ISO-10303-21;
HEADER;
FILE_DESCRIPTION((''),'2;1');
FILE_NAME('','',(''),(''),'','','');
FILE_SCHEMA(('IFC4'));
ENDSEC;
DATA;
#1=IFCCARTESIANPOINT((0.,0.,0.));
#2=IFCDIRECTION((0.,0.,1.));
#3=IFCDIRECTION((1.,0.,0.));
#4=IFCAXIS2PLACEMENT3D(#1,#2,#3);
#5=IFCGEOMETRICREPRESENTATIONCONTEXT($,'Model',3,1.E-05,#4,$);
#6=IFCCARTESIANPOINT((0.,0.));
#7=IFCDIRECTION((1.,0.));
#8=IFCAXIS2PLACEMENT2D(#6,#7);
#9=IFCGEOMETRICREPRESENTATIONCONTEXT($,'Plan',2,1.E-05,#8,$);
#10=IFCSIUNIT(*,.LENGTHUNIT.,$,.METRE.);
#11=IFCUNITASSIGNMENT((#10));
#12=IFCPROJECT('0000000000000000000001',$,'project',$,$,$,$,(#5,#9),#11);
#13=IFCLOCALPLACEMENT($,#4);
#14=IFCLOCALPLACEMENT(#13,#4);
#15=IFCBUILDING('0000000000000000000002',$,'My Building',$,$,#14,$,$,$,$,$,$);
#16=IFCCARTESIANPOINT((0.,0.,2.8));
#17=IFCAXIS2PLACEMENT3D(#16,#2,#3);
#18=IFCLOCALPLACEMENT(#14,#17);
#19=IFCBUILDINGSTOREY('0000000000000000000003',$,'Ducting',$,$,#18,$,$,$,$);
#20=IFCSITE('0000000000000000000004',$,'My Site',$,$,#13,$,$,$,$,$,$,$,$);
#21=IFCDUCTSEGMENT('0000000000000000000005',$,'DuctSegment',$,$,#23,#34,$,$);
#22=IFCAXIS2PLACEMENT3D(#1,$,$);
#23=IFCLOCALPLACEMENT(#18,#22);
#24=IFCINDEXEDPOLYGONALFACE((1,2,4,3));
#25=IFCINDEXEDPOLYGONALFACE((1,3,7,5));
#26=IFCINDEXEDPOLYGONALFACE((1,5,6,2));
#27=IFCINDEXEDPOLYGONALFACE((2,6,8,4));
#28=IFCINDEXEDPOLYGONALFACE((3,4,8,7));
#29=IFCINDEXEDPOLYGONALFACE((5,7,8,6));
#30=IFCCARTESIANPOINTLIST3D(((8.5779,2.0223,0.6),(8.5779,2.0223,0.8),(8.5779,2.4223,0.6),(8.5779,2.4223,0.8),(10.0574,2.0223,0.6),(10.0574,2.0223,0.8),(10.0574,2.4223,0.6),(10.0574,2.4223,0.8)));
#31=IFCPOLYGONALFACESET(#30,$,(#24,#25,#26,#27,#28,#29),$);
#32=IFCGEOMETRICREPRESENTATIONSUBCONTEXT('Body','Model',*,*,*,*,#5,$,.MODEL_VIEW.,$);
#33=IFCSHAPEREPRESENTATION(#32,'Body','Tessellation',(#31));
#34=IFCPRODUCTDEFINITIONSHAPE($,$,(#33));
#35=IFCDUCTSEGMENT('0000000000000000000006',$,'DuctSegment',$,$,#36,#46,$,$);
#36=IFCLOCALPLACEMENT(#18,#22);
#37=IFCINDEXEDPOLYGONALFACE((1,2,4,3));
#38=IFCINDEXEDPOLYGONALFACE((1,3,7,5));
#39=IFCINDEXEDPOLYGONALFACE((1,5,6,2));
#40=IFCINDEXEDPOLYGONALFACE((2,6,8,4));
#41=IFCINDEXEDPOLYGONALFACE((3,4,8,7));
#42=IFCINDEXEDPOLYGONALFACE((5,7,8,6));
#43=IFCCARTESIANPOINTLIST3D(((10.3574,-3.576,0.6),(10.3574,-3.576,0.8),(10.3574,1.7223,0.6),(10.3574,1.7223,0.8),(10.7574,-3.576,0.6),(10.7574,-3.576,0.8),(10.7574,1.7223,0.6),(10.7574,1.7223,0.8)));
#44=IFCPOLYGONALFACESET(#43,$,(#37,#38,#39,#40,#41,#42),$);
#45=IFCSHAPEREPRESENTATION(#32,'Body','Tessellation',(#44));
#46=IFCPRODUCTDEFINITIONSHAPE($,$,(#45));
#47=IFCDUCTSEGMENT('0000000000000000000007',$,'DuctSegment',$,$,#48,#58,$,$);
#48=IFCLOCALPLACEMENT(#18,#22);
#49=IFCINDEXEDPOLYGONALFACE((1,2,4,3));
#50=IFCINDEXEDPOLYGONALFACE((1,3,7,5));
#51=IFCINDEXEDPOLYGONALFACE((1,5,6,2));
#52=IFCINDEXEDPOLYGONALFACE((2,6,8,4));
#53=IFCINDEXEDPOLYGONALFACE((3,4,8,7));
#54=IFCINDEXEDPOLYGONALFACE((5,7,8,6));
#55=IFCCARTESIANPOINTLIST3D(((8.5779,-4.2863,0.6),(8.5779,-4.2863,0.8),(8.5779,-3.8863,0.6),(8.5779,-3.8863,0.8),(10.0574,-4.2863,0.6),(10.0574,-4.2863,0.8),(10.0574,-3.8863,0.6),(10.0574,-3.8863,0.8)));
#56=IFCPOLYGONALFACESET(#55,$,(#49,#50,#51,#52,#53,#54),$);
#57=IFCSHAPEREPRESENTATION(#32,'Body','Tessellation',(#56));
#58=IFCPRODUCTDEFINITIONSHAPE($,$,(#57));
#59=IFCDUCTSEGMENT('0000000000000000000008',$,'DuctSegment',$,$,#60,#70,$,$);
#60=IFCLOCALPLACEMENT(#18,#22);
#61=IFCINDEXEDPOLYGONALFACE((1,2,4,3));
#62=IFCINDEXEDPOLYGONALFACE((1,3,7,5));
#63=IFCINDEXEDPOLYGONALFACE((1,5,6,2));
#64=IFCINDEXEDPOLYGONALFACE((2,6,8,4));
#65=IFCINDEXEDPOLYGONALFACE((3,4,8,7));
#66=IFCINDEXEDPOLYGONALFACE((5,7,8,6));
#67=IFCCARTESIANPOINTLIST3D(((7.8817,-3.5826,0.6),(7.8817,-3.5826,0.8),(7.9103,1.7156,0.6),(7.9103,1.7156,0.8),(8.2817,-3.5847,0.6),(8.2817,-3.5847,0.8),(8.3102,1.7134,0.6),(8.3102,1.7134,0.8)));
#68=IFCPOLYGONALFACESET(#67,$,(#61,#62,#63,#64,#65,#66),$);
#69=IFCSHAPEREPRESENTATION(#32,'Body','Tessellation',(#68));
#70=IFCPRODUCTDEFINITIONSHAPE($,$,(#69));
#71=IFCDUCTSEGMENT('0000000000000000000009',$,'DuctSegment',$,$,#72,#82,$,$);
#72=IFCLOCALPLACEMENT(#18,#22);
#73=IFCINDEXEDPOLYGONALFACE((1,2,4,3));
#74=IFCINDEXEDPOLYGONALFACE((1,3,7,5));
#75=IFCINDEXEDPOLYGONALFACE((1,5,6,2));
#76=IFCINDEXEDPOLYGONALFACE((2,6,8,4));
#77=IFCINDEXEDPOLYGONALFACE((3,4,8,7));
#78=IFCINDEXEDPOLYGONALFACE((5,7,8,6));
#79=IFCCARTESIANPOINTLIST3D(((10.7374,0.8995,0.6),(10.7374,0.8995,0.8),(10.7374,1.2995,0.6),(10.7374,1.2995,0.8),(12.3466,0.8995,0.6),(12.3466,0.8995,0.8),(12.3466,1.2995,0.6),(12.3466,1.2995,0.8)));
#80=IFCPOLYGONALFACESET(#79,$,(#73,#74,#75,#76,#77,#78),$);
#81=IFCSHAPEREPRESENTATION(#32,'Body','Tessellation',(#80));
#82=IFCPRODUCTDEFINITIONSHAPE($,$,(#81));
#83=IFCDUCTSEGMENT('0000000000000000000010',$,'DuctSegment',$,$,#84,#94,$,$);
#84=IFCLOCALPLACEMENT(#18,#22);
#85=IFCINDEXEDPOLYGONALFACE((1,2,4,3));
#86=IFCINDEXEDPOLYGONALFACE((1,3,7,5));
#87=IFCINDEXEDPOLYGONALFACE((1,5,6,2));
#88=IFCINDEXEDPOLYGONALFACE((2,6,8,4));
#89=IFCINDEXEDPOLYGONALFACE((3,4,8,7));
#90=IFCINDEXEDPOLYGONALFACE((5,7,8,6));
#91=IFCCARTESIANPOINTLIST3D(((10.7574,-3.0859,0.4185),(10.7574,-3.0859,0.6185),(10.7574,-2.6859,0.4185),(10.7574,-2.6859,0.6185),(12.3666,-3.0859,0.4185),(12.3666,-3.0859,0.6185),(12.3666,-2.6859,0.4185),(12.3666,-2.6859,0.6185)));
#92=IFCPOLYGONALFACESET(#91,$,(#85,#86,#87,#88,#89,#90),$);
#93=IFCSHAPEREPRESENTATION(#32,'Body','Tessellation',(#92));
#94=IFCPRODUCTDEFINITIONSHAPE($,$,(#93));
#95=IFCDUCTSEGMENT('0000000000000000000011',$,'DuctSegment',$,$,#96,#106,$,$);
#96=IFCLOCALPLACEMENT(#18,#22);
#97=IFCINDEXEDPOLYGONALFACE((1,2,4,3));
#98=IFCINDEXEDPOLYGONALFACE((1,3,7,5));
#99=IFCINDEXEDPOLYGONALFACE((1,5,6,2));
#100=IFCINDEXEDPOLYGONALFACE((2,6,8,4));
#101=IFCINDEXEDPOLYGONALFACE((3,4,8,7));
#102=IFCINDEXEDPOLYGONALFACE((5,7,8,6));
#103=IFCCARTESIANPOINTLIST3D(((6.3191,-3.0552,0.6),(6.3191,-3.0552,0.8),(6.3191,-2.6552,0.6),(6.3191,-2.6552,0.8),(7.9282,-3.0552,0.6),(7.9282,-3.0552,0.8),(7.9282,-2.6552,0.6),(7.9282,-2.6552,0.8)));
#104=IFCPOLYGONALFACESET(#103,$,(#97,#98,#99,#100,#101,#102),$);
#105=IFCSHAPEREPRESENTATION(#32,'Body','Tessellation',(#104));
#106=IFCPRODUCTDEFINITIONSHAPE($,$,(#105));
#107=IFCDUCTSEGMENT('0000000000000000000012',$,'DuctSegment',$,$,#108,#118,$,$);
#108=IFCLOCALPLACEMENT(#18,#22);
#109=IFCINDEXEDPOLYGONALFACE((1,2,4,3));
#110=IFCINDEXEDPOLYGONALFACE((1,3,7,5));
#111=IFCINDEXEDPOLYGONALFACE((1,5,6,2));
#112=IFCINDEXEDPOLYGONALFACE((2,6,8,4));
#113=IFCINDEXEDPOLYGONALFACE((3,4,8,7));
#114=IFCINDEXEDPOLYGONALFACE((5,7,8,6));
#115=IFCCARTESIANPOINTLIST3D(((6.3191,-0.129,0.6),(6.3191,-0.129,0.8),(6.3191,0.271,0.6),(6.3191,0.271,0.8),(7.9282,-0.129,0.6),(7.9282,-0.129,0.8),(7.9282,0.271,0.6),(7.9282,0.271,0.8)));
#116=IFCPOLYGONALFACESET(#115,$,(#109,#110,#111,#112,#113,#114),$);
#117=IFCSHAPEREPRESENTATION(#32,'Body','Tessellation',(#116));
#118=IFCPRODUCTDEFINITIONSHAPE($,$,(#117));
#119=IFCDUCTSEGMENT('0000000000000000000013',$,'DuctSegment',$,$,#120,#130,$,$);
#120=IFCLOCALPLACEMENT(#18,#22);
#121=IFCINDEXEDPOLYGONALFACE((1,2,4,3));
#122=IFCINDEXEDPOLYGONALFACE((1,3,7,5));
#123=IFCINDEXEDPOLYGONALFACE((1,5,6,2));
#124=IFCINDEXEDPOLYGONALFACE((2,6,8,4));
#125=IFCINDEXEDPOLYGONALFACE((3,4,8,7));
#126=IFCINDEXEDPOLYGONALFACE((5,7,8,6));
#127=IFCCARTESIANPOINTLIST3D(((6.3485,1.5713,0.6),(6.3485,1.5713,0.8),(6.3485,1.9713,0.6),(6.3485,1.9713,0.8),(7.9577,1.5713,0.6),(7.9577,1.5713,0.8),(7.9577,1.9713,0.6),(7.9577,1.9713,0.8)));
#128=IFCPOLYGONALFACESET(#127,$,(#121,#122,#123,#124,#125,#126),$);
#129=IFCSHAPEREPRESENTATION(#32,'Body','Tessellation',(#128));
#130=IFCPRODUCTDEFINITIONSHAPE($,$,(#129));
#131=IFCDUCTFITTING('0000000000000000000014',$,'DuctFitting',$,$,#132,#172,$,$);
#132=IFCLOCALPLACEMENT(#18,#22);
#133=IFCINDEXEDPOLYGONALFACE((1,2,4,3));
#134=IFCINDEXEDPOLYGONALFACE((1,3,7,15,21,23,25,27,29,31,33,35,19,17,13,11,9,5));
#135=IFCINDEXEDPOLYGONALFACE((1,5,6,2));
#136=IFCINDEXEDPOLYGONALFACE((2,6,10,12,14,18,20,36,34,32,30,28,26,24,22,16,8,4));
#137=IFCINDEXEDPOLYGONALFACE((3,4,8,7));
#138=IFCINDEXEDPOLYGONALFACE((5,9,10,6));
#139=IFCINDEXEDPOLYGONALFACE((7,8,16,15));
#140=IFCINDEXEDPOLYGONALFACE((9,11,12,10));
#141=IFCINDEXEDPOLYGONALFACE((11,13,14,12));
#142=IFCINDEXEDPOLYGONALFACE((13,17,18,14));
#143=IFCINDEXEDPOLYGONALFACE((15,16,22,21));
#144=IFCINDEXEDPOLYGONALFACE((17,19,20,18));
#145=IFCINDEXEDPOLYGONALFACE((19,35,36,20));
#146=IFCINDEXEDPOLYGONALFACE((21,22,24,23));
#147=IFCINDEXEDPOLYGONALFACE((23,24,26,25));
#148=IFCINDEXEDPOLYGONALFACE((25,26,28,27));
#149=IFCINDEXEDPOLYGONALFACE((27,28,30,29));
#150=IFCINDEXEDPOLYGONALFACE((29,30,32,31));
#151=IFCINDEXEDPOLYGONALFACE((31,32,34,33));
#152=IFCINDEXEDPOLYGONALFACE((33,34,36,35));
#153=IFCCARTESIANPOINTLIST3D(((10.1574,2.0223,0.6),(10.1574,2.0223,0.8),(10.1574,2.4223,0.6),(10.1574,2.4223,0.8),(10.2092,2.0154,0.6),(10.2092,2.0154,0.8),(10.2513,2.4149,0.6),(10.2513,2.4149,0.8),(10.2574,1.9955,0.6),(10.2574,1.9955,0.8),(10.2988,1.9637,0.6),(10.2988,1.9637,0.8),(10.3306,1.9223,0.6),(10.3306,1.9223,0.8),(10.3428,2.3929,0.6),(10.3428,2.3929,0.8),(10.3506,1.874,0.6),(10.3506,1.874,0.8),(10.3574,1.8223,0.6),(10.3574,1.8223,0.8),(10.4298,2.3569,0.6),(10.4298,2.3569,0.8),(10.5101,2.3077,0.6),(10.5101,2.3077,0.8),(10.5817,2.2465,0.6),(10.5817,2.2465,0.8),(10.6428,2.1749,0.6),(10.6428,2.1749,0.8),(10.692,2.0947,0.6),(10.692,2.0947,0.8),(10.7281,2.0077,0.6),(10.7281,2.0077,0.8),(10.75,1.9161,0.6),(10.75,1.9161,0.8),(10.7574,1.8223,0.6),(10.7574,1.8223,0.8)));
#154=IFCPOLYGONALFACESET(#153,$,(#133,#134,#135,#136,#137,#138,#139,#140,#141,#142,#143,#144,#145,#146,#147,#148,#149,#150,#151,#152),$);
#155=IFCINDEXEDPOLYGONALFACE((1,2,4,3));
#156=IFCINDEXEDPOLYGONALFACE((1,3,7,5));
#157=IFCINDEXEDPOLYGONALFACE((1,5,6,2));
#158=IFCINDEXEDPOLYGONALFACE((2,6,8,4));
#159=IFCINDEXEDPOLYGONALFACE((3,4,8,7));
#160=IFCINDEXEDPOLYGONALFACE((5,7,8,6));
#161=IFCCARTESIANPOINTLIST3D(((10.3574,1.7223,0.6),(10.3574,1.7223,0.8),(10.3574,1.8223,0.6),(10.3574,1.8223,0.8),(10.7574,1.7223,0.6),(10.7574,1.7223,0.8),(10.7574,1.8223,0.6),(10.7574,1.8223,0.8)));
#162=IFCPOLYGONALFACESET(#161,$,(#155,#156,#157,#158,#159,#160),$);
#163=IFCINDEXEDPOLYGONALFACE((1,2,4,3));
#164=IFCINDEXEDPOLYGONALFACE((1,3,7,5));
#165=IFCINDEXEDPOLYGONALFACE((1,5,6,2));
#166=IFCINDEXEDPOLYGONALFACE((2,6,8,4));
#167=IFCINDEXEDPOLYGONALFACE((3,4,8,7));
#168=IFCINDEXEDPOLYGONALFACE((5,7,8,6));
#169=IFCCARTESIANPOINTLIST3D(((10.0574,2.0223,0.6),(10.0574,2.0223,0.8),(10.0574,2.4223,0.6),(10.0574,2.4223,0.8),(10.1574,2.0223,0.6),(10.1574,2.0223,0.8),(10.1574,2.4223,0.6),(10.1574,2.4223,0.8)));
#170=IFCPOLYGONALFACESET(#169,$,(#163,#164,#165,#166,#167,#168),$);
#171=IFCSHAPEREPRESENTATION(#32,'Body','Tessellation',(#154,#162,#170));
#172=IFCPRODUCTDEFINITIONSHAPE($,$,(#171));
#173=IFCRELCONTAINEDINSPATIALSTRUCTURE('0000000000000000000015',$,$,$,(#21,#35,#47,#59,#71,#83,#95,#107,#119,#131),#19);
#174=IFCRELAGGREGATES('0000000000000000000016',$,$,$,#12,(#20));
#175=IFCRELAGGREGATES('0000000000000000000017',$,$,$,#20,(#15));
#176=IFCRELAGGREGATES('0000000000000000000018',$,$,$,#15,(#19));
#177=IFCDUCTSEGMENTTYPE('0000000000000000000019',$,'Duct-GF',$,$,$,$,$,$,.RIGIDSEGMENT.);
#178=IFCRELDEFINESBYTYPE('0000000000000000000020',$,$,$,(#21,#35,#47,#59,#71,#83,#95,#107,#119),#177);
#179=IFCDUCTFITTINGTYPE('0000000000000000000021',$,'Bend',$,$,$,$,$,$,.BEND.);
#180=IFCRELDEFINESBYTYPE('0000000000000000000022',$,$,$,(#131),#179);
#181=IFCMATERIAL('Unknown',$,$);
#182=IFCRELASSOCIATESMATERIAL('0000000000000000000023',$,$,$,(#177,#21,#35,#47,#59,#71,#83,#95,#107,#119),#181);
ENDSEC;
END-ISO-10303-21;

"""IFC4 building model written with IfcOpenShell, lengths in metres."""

from ifc_helpers import new_model, si_unit, frame, origin_with_axes, origin_2d_with_axis, place, context, subcontext, project, spatial, line, arc, indexed_curve, rectangle, outline, extrude, source, transform, mapped, material, material_profile, profile_set, profile_usage, type_object, type_shapes, element, save


model = new_model("IFC4")

# Units and contexts
model_context = context("Model", 3, precision=1e-05, world=origin_with_axes())
plan_context = context("Plan", 2, precision=1e-05, world=origin_2d_with_axis())
body_context = subcontext(model_context, "Body", "Model", "MODEL_VIEW")
ifc_project = project(units=[si_unit("LENGTHUNIT", "METRE")], contexts=[model_context, plan_context])

# Site, building, storey
site_placement = place(None, origin_with_axes())
site = spatial("IfcSite", under=ifc_project, at=site_placement, Name="My Site")
building_placement = place(site_placement, origin_with_axes())
building = spatial("IfcBuilding", under=site, at=building_placement, Name="My Building")
storey_placement = place(building_placement, frame((0.0, 0.0, 2.8), z_axis=(0.0, 0.0, 1.0), x_axis=(1.0, 0.0, 0.0)))
storey = spatial("IfcBuildingStorey", under=building, at=storey_placement, Name="Ducting")

# Duct segments
ifc_material = material(Name="Unknown")
ifc_material_profile_1 = material_profile(ifc_material, rectangle(XDim=0.4, YDim=0.2))
ifc_profile_set_1 = profile_set([ifc_material_profile_1])
ifc_profile_usage_1 = profile_usage(ifc_profile_set_1, cardinal=5)
duct_segment_type = type_object("IfcDuctSegmentType", Name="Duct-GF", PredefinedType="RIGIDSEGMENT", material=ifc_profile_set_1)
duct_segment_1_placement = place(storey_placement, frame((8.5779, 2.2223, 0.7), z_axis=(1.0, -0.000001, 0.000001), x_axis=(0.000001, 1.0, 0.0)))
element("IfcDuctSegment", 1, at=duct_segment_1_placement, inside=storey, type_object=duct_segment_type, material=ifc_profile_usage_1, Name="DuctSegment", context=body_context, shape_type="SweptSolid", body=[
    extrude(rectangle(XDim=0.4, YDim=0.2), origin_with_axes(), (0.0, 0.0, 1.0), 1.4795),
])
ifc_profile_usage_2 = profile_usage(ifc_profile_set_1, cardinal=5)
duct_segment_2_placement = place(storey_placement, frame((10.5574, 1.7223, 0.7), z_axis=(0.0, -1.0, 0.0), x_axis=(-1.0, 0.0, 0.0)))
element("IfcDuctSegment", 2, at=duct_segment_2_placement, inside=storey, type_object=duct_segment_type, material=ifc_profile_usage_2, Name="DuctSegment", context=body_context, shape_type="SweptSolid", body=[
    extrude(rectangle(XDim=0.4, YDim=0.2), origin_with_axes(), (0.0, 0.0, 1.0), 5.2983),
])
ifc_profile_usage_3 = profile_usage(ifc_profile_set_1, cardinal=5)
duct_segment_3_placement = place(storey_placement, frame((8.5779, -4.0863, 0.7), z_axis=(1.0, -0.000001, 0.000001), x_axis=(0.000001, 1.0, 0.0)))
element("IfcDuctSegment", 3, at=duct_segment_3_placement, inside=storey, type_object=duct_segment_type, material=ifc_profile_usage_3, Name="DuctSegment", context=body_context, shape_type="SweptSolid", body=[
    extrude(rectangle(XDim=0.4, YDim=0.2), origin_with_axes(), (0.0, 0.0, 1.0), 1.4795),
])
ifc_profile_usage_4 = profile_usage(ifc_profile_set_1, cardinal=5)
duct_segment_4_placement = place(storey_placement, frame((8.0817, -3.5837, 0.7), z_axis=(0.005395, 0.999985, 0.0), x_axis=(0.999985, -0.005395, 0.0)))
element("IfcDuctSegment", 4, at=duct_segment_4_placement, inside=storey, type_object=duct_segment_type, material=ifc_profile_usage_4, Name="DuctSegment", context=body_context, shape_type="SweptSolid", body=[
    extrude(rectangle(XDim=0.4, YDim=0.2), origin_with_axes(), (0.0, 0.0, 1.0), 5.2983),
])
ifc_profile_usage_5 = profile_usage(ifc_profile_set_1, cardinal=5)
duct_segment_5_placement = place(storey_placement, frame((10.7374, 1.0995, 0.7), z_axis=(1.0, 0.0, 0.0), x_axis=(0.0, 1.0, 0.0)))
element("IfcDuctSegment", 5, at=duct_segment_5_placement, inside=storey, type_object=duct_segment_type, material=ifc_profile_usage_5, Name="DuctSegment", context=body_context, shape_type="SweptSolid", body=[
    extrude(rectangle(XDim=0.4, YDim=0.2), origin_with_axes(), (0.0, 0.0, 1.0), 1.6092),
])
ifc_profile_usage_6 = profile_usage(ifc_profile_set_1, cardinal=5)
duct_segment_6_placement = place(storey_placement, frame((10.7574, -2.8859, 0.5185), z_axis=(1.0, 0.0, 0.0), x_axis=(0.0, 1.0, 0.0)))
element("IfcDuctSegment", 6, at=duct_segment_6_placement, inside=storey, type_object=duct_segment_type, material=ifc_profile_usage_6, Name="DuctSegment", context=body_context, shape_type="SweptSolid", body=[
    extrude(rectangle(XDim=0.4, YDim=0.2), origin_with_axes(), (0.0, 0.0, 1.0), 1.6092),
])
ifc_profile_usage_7 = profile_usage(ifc_profile_set_1, cardinal=5)
duct_segment_7_placement = place(storey_placement, frame((6.3191, -2.8552, 0.7), z_axis=(1.0, 0.0, 0.0), x_axis=(0.0, 1.0, 0.0)))
element("IfcDuctSegment", 7, at=duct_segment_7_placement, inside=storey, type_object=duct_segment_type, material=ifc_profile_usage_7, Name="DuctSegment", context=body_context, shape_type="SweptSolid", body=[
    extrude(rectangle(XDim=0.4, YDim=0.2), origin_with_axes(), (0.0, 0.0, 1.0), 1.6092),
])
ifc_profile_usage_8 = profile_usage(ifc_profile_set_1, cardinal=5)
duct_segment_8_placement = place(storey_placement, frame((6.3191, 0.071, 0.7), z_axis=(1.0, 0.0, 0.0), x_axis=(0.0, 1.0, 0.0)))
element("IfcDuctSegment", 8, at=duct_segment_8_placement, inside=storey, type_object=duct_segment_type, material=ifc_profile_usage_8, Name="DuctSegment", context=body_context, shape_type="SweptSolid", body=[
    extrude(rectangle(XDim=0.4, YDim=0.2), origin_with_axes(), (0.0, 0.0, 1.0), 1.6092),
])
ifc_profile_usage_9 = profile_usage(ifc_profile_set_1, cardinal=5)
duct_segment_9_placement = place(storey_placement, frame((6.3485, 1.7713, 0.7), z_axis=(1.0, 0.0, 0.0), x_axis=(0.0, 1.0, 0.0)))
element("IfcDuctSegment", 9, at=duct_segment_9_placement, inside=storey, type_object=duct_segment_type, material=ifc_profile_usage_9, Name="DuctSegment", context=body_context, shape_type="SweptSolid", body=[
    extrude(rectangle(XDim=0.4, YDim=0.2), origin_with_axes(), (0.0, 0.0, 1.0), 1.6092),
])

# Duct fitting
duct_fitting_type = type_object("IfcDuctFittingType", Name="Bend", PredefinedType="BEND")
shared_shape_1 = source(origin_with_axes(), body_context, "Body", "SweptSolid", [
    extrude(outline(indexed_curve([(0.2, 0.0), (0.2586, -0.1414), (0.4, -0.2), (0.4, -0.6), (-0.0243, -0.4243), (-0.2, 0.0)], segments=[arc(1, 2, 3), line(3, 4), arc(4, 5, 6), line(6, 1)])), frame((0.0, -0.1, -0.1), z_axis=(0.0, -1.0, 0.0), x_axis=(1.0, 0.0, 0.0)), (0.0, 0.0, -1.0), 0.2),
    extrude(rectangle(XDim=0.4, YDim=0.2), origin_with_axes(), (0.0, 0.0, -1.0), 0.1),
    extrude(rectangle(XDim=0.4, YDim=0.2), frame((0.4, 0.0, -0.5), z_axis=(1.0, 0.0, -0.000001), x_axis=(0.000001, 0.0, 1.0)), (0.0, 0.0, 1.0), 0.1),
])
type_shapes(duct_fitting_type, [shared_shape_1])
for number, where, z_axis, x_axis, name in (
    (10, (10.5574, 1.7223, 0.7), (0.0, -1.0, 0.0), (-1.0, 0.0, 0.0), "DuctFitting"),
):
    element("IfcDuctFitting", number, at=place(storey_placement, frame(where, z_axis=z_axis, x_axis=x_axis)), inside=storey, type_object=duct_fitting_type, Name=name, context=body_context, shape_type="MappedRepresentation", body=[
        mapped(shared_shape_1, transform((0.0, 0.0, 0.0), x_axis=(1.0, 0.0, 0.0), y_axis=(0.0, 1.0, 0.0), z_axis=(0.0, 0.0, 1.0), scale=1.0)),
    ])

save(model, "model.ifc")
